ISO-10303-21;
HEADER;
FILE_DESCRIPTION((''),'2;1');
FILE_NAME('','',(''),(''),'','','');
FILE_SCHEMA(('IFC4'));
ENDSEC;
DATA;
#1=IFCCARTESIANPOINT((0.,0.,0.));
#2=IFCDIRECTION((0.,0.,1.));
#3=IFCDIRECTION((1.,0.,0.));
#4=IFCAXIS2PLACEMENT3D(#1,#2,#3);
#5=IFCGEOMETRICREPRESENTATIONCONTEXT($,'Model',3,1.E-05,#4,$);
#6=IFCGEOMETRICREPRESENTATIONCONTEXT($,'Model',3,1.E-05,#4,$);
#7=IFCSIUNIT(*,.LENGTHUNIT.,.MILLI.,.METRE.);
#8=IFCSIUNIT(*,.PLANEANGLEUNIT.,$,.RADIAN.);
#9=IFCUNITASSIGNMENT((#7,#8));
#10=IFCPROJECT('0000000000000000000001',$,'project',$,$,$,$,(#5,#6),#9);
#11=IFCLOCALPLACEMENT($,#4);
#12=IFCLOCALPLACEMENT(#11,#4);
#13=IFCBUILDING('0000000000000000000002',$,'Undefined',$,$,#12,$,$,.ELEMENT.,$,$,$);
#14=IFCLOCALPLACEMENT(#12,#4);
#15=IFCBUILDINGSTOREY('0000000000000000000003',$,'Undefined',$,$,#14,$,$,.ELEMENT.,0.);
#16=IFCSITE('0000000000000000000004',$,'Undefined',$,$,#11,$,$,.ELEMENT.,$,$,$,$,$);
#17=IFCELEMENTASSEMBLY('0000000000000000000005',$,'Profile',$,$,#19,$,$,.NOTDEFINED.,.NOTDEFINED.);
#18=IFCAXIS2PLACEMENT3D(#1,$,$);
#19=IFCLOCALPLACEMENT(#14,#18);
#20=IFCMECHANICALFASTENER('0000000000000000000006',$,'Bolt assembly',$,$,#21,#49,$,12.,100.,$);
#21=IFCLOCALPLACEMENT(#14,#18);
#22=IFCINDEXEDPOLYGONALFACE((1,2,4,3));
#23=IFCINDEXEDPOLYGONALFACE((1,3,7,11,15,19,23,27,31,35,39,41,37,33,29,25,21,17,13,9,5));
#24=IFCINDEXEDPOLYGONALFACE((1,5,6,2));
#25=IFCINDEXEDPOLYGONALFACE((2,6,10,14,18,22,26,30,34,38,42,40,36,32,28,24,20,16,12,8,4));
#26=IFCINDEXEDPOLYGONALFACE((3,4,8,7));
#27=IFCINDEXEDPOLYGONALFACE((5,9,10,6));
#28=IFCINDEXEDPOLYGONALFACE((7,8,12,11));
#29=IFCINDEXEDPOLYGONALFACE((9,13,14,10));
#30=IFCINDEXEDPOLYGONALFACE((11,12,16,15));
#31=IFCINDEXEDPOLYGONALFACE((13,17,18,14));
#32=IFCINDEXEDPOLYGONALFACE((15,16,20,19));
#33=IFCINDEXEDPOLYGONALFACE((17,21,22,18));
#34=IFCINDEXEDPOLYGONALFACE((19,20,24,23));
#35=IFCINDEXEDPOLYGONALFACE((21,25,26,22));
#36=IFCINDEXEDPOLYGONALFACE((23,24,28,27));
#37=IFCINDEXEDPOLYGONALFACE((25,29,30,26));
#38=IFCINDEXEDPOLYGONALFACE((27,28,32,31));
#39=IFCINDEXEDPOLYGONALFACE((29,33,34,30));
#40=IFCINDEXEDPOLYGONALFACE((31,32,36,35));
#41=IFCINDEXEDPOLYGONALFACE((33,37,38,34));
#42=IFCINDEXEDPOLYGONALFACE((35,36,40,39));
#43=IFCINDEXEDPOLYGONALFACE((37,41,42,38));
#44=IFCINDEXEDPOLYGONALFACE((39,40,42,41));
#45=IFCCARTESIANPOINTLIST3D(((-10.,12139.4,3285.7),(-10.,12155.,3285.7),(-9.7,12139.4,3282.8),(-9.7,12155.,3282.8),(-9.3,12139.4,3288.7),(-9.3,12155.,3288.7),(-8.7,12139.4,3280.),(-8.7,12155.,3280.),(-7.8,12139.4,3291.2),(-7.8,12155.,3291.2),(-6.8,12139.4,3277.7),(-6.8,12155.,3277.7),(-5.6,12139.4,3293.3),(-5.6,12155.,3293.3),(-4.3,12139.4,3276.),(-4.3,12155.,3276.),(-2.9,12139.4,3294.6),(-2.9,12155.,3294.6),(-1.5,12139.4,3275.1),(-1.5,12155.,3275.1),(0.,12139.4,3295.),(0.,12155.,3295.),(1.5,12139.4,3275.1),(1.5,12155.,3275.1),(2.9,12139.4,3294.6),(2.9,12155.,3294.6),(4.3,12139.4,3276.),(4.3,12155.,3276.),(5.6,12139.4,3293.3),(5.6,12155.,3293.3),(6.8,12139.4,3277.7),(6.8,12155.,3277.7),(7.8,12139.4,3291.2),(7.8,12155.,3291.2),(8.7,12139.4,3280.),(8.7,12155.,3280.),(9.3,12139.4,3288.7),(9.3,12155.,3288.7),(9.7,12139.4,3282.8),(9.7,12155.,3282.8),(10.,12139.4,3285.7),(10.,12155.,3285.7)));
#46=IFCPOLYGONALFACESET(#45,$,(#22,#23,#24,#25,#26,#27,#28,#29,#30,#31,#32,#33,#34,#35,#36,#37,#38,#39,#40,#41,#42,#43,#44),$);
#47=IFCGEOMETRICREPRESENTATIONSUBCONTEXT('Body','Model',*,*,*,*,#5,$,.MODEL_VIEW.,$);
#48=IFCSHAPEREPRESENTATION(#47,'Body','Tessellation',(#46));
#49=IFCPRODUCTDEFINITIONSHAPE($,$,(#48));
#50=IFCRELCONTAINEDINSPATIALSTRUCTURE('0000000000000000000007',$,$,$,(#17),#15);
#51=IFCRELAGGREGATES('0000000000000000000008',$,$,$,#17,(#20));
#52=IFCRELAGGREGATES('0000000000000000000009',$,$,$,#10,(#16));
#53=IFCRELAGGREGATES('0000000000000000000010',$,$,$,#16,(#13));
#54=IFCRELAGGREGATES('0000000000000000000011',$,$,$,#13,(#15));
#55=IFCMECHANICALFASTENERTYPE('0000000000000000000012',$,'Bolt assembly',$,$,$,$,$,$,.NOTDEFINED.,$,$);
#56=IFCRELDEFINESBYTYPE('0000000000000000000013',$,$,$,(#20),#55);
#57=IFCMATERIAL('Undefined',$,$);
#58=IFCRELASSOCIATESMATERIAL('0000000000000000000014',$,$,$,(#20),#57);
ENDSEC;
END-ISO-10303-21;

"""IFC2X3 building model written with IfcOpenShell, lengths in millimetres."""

from ifc_helpers import new_model, si_unit, frame, origin_with_axes, origin_2d_with_axis, place, context, subcontext, project, spatial, circle, extrude, source, transform, mapped, material, type_object, element, aggregate, save


model = new_model("IFC2X3")

# Units and contexts
model_context_1 = context("Model", 3, precision=1e-05, world=origin_with_axes())
model_context_2 = context("Model", 3, precision=1e-05, world=origin_with_axes())
body_context = subcontext(model_context_1, "Body", "Model", "MODEL_VIEW")
ifc_project = project(units=[si_unit("LENGTHUNIT", "METRE", prefix="MILLI"), si_unit("PLANEANGLEUNIT", "RADIAN")], contexts=[model_context_1, model_context_2])

# Site, building, storey
site_placement = place(None, origin_with_axes())
site = spatial("IfcSite", under=ifc_project, at=site_placement, Name="Undefined", CompositionType="ELEMENT")
building_placement = place(site_placement, origin_with_axes())
building = spatial("IfcBuilding", under=site, at=building_placement, Name="Undefined", CompositionType="ELEMENT")
storey_placement = place(building_placement, origin_with_axes())
storey = spatial("IfcBuildingStorey", under=building, at=storey_placement, Name="Undefined", CompositionType="ELEMENT", Elevation=0.0)

# Element assembly
assembly_1_placement = place(storey_placement, origin_with_axes())
assembly_1 = element("IfcElementAssembly", 1, at=assembly_1_placement, inside=storey, Name="Profile", AssemblyPlace="NOTDEFINED", PredefinedType="NOTDEFINED")

# Mechanical fastener
mechanical_fastener_type = type_object("IfcMechanicalFastenerType", Name="Bolt assembly")
ifc_material_1 = material(Name="Undefined")
shared_shape_1 = source(origin_with_axes(), body_context, "Body", "SweptSolid", [
    extrude(circle(Radius=10.0, at=origin_2d_with_axis()), frame((0.0, 0.0, 0.0), z_axis=(0.0, 1.0, 0.0), x_axis=(1.0, 0.0, 0.0)), (0.0, 0.0, 1.0), 15.6),
])
mechanical_fastener_1_placement = place(assembly_1_placement, frame((0.0, 12155.0, 3285.0), z_axis=(1.0, 0.0, 0.0), x_axis=(0.0, 0.0, 1.0)))
mechanical_fastener_1 = element("IfcMechanicalFastener", 2, at=mechanical_fastener_1_placement, type_object=mechanical_fastener_type, material=ifc_material_1, Name="Bolt assembly", NominalDiameter=12.0, NominalLength=100.0, context=body_context, shape_type="MappedRepresentation", body=[
    mapped(shared_shape_1, transform((0.0, 0.0, 0.0))),
])
aggregate(assembly_1, [mechanical_fastener_1])

save(model, "model.ifc")
